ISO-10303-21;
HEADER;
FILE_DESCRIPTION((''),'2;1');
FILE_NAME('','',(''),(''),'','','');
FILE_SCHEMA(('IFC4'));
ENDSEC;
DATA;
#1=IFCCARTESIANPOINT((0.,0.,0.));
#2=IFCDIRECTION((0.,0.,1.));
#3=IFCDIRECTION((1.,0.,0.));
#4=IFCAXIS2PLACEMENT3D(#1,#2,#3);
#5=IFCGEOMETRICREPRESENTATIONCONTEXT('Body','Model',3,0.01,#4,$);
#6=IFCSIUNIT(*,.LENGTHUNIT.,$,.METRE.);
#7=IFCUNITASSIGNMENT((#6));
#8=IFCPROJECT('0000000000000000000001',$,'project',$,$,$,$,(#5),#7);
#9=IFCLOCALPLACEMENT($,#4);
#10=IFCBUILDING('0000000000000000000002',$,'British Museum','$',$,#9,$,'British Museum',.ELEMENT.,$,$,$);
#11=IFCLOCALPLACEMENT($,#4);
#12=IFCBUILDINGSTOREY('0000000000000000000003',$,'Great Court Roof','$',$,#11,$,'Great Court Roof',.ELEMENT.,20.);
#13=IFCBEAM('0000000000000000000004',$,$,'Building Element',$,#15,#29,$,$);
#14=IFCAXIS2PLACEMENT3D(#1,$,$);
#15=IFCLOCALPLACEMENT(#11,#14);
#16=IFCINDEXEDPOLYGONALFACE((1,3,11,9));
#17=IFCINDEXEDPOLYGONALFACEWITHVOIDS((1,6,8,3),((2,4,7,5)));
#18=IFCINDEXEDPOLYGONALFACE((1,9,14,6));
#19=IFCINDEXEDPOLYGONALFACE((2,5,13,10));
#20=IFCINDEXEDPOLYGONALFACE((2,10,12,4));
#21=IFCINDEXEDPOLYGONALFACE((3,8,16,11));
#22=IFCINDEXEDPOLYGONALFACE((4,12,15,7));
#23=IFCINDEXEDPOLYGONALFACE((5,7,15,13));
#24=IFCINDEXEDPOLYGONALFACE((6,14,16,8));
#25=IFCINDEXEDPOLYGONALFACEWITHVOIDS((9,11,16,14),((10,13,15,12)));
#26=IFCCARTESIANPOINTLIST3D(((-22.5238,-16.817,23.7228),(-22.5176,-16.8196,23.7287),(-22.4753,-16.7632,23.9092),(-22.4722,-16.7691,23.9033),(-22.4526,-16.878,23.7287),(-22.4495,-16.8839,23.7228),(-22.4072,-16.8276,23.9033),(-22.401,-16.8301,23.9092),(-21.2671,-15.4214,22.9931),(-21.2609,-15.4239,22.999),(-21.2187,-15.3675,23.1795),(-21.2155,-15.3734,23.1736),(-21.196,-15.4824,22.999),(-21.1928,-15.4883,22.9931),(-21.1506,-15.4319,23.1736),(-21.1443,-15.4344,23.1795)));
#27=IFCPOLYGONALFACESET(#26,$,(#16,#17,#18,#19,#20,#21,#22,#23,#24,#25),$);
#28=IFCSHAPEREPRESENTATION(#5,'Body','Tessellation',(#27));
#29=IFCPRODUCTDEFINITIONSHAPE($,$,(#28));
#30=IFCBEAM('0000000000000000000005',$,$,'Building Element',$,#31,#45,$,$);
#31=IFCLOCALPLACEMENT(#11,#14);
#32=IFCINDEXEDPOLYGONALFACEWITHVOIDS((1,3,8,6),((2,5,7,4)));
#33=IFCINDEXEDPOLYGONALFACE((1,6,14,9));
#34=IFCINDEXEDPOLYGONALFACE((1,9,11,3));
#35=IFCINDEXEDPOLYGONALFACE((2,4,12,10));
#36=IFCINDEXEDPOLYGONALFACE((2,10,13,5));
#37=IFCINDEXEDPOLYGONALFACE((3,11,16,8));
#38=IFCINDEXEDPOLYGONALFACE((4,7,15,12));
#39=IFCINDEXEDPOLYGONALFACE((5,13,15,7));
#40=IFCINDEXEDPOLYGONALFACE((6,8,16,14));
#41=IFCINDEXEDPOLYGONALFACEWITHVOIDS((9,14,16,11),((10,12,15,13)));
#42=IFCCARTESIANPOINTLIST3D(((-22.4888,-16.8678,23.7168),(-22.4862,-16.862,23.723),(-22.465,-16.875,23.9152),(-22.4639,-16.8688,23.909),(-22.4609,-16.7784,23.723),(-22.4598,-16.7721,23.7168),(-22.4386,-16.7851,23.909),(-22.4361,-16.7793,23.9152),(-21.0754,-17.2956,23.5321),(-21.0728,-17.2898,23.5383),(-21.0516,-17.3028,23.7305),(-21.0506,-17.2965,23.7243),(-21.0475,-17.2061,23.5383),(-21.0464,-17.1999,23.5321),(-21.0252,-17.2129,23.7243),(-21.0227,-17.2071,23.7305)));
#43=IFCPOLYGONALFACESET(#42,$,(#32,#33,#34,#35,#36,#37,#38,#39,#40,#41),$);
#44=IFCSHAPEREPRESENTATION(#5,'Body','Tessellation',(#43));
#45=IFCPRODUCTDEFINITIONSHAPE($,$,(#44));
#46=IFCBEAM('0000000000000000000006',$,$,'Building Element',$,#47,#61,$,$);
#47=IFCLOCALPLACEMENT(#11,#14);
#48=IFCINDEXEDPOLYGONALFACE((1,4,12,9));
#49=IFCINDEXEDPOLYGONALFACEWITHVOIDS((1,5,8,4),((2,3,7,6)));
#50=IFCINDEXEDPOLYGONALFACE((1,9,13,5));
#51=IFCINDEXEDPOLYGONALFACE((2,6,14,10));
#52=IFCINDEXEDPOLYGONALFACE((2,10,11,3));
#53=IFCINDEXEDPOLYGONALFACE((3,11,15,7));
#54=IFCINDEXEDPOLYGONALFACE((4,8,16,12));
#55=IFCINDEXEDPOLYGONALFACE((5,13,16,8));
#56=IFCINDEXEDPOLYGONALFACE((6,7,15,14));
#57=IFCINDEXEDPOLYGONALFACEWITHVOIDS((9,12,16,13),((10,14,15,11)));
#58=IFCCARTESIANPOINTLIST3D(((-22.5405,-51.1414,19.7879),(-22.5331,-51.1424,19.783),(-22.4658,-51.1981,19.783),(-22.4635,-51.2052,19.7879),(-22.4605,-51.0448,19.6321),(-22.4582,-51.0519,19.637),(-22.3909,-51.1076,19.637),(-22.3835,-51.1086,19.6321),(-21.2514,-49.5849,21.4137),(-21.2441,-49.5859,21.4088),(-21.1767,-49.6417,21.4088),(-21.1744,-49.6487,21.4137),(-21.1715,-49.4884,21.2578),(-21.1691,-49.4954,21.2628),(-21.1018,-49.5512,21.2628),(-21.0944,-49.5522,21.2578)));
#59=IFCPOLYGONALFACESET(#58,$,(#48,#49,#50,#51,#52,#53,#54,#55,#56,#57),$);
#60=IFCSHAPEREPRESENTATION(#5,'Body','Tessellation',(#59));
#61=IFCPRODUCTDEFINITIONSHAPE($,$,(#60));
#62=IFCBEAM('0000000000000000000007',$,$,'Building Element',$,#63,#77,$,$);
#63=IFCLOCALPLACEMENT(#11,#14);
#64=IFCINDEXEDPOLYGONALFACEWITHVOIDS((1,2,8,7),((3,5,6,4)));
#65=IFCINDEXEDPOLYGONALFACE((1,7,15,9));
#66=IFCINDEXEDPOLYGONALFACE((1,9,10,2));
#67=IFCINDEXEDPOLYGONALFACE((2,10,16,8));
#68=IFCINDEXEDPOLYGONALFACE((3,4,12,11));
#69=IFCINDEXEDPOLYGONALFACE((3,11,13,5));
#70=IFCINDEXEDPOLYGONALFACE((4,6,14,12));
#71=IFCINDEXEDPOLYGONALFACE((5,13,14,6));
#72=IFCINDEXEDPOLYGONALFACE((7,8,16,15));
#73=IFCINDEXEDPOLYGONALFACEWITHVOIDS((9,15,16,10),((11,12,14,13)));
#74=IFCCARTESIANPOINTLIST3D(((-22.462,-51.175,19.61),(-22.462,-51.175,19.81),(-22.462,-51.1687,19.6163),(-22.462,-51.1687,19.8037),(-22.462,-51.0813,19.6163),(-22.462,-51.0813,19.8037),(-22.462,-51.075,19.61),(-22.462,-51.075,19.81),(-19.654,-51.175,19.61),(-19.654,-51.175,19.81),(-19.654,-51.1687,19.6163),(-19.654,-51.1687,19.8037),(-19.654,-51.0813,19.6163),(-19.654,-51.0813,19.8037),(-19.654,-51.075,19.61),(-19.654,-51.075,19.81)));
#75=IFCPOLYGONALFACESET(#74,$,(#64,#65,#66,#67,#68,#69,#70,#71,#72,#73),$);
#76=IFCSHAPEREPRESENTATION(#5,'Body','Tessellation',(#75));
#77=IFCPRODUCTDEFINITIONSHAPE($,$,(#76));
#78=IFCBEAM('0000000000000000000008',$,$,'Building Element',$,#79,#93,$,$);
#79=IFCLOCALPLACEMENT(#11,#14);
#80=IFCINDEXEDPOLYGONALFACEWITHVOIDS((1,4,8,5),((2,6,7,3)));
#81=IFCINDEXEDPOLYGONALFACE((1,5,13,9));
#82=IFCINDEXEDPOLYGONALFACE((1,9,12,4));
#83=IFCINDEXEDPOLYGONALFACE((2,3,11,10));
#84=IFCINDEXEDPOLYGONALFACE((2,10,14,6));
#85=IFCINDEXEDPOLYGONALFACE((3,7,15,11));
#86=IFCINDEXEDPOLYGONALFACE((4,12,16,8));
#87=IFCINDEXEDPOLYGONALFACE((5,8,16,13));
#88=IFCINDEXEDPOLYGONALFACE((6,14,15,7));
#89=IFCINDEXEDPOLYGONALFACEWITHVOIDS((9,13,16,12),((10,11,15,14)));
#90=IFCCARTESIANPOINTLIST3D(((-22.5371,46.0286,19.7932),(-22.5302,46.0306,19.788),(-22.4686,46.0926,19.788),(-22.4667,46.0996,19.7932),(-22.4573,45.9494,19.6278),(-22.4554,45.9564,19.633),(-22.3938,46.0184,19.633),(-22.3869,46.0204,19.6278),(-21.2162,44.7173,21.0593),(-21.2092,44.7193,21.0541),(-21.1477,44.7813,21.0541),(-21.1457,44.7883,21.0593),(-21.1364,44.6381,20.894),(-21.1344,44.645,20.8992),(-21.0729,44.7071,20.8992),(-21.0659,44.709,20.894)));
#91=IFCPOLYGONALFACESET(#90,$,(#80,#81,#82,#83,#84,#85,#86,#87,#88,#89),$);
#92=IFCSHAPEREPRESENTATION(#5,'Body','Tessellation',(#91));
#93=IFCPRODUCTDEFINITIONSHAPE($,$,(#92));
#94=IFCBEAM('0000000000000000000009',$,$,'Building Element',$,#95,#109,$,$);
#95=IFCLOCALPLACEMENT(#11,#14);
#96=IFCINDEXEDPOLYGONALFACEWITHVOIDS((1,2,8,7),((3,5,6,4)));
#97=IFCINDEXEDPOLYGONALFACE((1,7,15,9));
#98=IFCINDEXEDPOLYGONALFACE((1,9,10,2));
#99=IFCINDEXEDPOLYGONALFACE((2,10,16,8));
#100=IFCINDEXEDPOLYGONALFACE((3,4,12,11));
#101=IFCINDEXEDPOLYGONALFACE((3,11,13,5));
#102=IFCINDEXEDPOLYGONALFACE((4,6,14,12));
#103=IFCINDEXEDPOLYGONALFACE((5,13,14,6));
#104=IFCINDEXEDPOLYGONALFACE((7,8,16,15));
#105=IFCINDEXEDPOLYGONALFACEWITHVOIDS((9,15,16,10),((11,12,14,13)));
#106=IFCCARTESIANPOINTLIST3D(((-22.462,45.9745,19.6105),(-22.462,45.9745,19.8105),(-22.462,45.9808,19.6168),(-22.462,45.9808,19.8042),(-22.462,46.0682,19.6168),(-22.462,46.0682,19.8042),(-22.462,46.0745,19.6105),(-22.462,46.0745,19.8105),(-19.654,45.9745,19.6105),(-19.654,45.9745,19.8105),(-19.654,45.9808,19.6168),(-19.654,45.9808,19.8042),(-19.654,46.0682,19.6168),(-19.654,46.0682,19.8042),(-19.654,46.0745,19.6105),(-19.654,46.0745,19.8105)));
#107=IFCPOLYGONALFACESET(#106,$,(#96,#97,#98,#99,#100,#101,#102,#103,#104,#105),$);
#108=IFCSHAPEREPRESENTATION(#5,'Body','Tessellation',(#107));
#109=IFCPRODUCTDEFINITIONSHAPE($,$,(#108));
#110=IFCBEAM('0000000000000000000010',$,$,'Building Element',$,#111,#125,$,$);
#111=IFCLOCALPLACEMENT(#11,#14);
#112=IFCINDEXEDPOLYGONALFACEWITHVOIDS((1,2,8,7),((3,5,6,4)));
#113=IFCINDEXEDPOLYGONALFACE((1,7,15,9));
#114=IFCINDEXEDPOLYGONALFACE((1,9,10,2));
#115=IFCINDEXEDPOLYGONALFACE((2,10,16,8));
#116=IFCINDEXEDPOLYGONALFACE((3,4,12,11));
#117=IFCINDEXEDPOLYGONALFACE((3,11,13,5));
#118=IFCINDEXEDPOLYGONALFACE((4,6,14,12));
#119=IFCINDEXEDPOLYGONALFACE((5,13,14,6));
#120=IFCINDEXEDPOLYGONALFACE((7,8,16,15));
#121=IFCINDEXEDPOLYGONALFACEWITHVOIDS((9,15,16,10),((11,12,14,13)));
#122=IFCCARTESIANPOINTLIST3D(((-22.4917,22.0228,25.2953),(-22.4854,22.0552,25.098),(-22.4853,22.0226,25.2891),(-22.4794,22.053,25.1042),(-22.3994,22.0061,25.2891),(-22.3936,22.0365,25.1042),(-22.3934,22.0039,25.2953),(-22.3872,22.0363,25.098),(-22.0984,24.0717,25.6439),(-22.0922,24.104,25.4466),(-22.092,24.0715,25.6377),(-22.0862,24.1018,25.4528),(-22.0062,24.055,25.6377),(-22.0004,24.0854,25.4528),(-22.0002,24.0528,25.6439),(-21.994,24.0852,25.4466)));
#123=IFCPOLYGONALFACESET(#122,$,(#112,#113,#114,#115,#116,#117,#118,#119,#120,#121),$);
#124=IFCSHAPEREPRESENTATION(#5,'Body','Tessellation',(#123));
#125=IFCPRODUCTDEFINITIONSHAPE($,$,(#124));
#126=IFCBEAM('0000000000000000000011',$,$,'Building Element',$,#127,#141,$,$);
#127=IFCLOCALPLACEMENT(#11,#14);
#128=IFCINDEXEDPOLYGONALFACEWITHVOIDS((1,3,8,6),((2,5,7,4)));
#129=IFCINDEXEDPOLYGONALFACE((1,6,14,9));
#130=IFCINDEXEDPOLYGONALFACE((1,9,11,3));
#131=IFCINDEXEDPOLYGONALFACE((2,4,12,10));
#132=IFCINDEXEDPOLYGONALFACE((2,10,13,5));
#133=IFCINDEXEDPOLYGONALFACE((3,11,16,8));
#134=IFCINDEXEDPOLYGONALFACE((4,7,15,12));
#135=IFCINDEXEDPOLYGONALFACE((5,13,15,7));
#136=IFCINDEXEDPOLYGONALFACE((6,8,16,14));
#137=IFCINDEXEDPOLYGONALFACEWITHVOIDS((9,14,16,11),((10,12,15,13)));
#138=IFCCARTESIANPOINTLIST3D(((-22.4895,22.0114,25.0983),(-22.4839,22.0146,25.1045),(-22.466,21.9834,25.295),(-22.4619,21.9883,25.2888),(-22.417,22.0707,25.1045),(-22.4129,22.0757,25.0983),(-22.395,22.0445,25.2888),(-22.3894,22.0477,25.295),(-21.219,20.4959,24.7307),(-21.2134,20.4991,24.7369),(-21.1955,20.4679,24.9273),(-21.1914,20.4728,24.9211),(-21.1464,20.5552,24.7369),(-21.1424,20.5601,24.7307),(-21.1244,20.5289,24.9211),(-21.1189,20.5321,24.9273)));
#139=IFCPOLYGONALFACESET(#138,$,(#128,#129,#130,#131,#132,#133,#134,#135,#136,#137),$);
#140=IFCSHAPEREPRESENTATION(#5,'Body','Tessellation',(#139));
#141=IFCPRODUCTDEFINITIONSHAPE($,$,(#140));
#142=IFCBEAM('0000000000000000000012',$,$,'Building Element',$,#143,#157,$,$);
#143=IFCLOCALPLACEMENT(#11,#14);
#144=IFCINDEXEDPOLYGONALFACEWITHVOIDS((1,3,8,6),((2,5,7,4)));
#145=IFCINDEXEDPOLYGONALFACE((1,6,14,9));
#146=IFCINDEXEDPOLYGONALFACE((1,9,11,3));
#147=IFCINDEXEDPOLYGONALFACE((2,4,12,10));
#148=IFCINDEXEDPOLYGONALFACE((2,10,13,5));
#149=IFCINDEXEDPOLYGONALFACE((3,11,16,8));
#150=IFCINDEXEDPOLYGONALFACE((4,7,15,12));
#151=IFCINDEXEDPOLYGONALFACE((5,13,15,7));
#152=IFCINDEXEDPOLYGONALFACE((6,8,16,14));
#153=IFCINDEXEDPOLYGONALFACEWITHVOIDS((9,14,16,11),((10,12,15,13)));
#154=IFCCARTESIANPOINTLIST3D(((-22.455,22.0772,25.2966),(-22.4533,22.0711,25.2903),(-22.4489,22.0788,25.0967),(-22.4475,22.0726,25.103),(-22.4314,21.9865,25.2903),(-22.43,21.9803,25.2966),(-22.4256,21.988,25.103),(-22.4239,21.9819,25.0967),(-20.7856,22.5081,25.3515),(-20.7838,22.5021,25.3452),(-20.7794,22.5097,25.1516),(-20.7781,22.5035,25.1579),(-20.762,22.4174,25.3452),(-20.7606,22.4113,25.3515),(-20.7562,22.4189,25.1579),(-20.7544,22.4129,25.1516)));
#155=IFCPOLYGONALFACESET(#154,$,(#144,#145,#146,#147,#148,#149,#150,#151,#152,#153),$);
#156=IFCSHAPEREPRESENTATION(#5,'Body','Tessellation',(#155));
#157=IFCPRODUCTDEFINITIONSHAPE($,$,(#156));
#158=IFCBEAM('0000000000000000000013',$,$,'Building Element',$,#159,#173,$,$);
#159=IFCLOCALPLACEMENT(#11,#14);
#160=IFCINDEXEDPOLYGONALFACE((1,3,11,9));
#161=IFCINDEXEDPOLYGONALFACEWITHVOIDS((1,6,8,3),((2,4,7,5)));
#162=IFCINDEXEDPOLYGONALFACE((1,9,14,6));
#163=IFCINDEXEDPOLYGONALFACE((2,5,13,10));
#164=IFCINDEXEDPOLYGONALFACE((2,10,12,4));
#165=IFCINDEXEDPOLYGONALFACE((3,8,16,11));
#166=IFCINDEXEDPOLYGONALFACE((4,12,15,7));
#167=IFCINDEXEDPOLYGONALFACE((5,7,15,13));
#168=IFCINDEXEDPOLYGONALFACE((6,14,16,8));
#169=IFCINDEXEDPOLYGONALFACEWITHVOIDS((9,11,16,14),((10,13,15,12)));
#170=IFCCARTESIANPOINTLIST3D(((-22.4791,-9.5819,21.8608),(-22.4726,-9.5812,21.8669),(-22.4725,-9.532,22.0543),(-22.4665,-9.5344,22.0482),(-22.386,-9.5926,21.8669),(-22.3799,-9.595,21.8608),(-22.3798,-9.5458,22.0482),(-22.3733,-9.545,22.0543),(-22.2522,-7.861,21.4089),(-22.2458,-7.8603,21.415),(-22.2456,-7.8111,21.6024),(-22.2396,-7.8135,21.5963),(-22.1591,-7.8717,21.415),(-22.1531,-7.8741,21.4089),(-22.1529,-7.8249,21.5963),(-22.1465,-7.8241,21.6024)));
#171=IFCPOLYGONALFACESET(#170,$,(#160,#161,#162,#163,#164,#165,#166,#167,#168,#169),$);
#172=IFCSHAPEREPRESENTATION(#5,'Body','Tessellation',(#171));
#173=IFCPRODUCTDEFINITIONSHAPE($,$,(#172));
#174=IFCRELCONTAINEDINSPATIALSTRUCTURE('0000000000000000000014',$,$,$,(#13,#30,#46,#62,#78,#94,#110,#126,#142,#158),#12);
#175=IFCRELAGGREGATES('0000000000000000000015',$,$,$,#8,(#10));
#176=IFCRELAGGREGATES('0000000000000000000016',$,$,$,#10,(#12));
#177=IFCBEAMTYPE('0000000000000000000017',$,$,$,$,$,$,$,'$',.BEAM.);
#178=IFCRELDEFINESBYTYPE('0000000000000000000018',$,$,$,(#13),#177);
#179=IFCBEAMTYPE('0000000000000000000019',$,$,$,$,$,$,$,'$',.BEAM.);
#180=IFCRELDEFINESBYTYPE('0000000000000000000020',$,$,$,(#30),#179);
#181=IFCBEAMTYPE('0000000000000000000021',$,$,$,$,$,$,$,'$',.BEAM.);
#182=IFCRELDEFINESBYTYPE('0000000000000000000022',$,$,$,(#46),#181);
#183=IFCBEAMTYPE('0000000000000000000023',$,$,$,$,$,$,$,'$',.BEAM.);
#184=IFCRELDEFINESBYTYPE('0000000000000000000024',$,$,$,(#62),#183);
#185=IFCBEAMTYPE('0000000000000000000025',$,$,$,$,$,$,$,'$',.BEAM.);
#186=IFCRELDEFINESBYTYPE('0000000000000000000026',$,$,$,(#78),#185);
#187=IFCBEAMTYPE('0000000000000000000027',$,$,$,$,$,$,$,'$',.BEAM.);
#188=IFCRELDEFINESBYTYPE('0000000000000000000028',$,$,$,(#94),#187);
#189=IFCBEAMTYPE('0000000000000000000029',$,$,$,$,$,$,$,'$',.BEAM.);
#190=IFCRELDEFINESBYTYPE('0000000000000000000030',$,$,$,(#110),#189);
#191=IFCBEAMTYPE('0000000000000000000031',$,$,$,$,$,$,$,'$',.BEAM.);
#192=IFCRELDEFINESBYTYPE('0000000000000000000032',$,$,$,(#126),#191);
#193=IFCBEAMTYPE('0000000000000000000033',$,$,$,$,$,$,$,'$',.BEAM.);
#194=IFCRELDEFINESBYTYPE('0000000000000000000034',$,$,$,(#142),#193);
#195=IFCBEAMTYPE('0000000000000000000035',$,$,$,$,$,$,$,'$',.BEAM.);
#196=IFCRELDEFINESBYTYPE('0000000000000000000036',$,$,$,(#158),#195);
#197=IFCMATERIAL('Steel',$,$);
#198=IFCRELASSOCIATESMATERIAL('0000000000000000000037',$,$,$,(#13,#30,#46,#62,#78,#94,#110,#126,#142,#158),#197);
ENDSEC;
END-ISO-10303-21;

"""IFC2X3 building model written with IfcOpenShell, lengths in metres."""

from ifc_helpers import new_model, si_unit, frame, origin_with_axes, origin_2d, place, context, project, spatial, hollow_rectangle, extrude, material, type_object, element, save


model = new_model("IFC2X3")

# Units and contexts
model_context = context("Model", 3, precision=0.01, world=origin_with_axes(), identifier="Body")
ifc_project = project(units=[si_unit("LENGTHUNIT", "METRE")], contexts=[model_context])

# Building, storey
building_placement = place(None, origin_with_axes())
building = spatial("IfcBuilding", under=ifc_project, at=building_placement, Name="British Museum", Description="$", LongName="British Museum", CompositionType="ELEMENT")
storey_placement = place(None, origin_with_axes())
storey = spatial("IfcBuildingStorey", under=building, at=storey_placement, Name="Great Court Roof", Description="$", LongName="Great Court Roof", CompositionType="ELEMENT", Elevation=20.0)

# Beams
ifc_material = material(Name="Steel")
beam_type_1 = type_object("IfcBeamType", ElementType="$", PredefinedType="BEAM")
beam_1_placement = place(None, origin_with_axes())
element("IfcBeam", 1, at=beam_1_placement, inside=storey, type_object=beam_type_1, material=ifc_material, Description="Building Element", context=model_context, shape_type="SweptSolid", body=[
    extrude(hollow_rectangle(XDim=0.1, YDim=0.2, WallThickness=0.0063, InnerFilletRadius=-0.0063, OuterFilletRadius=0.0, at=origin_2d()), frame((-22.4624, -16.8236, 23.816), z_axis=(0.623709, 0.692696, -0.362158), x_axis=(-0.743143, 0.669132, 0.0)), (0.0, 0.0, 1.0), 2.0148),
])
beam_type_2 = type_object("IfcBeamType", ElementType="$", PredefinedType="BEAM")
beam_2_placement = place(None, origin_with_axes())
element("IfcBeam", 2, at=beam_2_placement, inside=storey, type_object=beam_type_2, material=ifc_material, Description="Building Element", context=model_context, shape_type="SweptSolid", body=[
    extrude(hollow_rectangle(XDim=0.1, YDim=0.2, WallThickness=0.0063, InnerFilletRadius=-0.0063, OuterFilletRadius=0.0, at=origin_2d()), frame((-22.4624, -16.8236, 23.816), z_axis=(0.94973, -0.287426, -0.124095), x_axis=(0.289665, 0.957128, 0.0)), (0.0, 0.0, 1.0), 1.4882),
])
beam_type_3 = type_object("IfcBeamType", ElementType="$", PredefinedType="BEAM")
beam_3_placement = place(None, origin_with_axes())
element("IfcBeam", 3, at=beam_3_placement, inside=storey, type_object=beam_type_3, material=ifc_material, Description="Building Element", context=model_context, shape_type="SweptSolid", body=[
    extrude(hollow_rectangle(XDim=0.1, YDim=0.2, WallThickness=0.0063, InnerFilletRadius=-0.0063, OuterFilletRadius=0.0, at=origin_2d()), frame((-22.462, -51.125, 19.71), z_axis=(0.496997, 0.600088, 0.626809), x_axis=(-0.770159, 0.637851, 0.0)), (0.0, 0.0, 1.0), 2.5937),
])
beam_type_4 = type_object("IfcBeamType", ElementType="$", PredefinedType="BEAM")
beam_4_placement = place(None, origin_with_axes())
element("IfcBeam", 4, at=beam_4_placement, inside=storey, type_object=beam_type_4, material=ifc_material, Description="Building Element", context=model_context, shape_type="SweptSolid", body=[
    extrude(hollow_rectangle(XDim=0.1, YDim=0.2, WallThickness=0.0063, InnerFilletRadius=-0.0063, OuterFilletRadius=0.0, at=origin_2d()), frame((-22.462, -51.125, 19.71), z_axis=(1.0, 0.0, 0.0), x_axis=(0.0, 1.0, 0.0)), (0.0, 0.0, 1.0), 2.808),
])
beam_type_5 = type_object("IfcBeamType", ElementType="$", PredefinedType="BEAM")
beam_5_placement = place(None, origin_with_axes())
element("IfcBeam", 5, at=beam_5_placement, inside=storey, type_object=beam_type_5, material=ifc_material, Description="Building Element", context=model_context, shape_type="SweptSolid", body=[
    extrude(hollow_rectangle(XDim=0.1, YDim=0.2, WallThickness=0.0063, InnerFilletRadius=-0.0063, OuterFilletRadius=0.0, at=origin_2d()), frame((-22.462, 46.0245, 19.7105), z_axis=(0.586789, -0.582511, 0.562458), x_axis=(0.704515, 0.709689, 0.0)), (0.0, 0.0, 1.0), 2.2512),
])
beam_type_6 = type_object("IfcBeamType", ElementType="$", PredefinedType="BEAM")
beam_6_placement = place(None, origin_with_axes())
element("IfcBeam", 6, at=beam_6_placement, inside=storey, type_object=beam_type_6, material=ifc_material, Description="Building Element", context=model_context, shape_type="SweptSolid", body=[
    extrude(hollow_rectangle(XDim=0.1, YDim=0.2, WallThickness=0.0063, InnerFilletRadius=-0.0063, OuterFilletRadius=0.0, at=origin_2d()), frame((-22.462, 46.0245, 19.7105), z_axis=(1.0, 0.0, 0.000011), x_axis=(0.0, 1.0, 0.0)), (0.0, 0.0, 1.0), 2.808),
])
beam_type_7 = type_object("IfcBeamType", ElementType="$", PredefinedType="BEAM")
beam_7_placement = place(None, origin_with_axes())
element("IfcBeam", 7, at=beam_7_placement, inside=storey, type_object=beam_type_7, material=ifc_material, Description="Building Element", context=model_context, shape_type="SweptSolid", body=[
    extrude(hollow_rectangle(XDim=0.1, YDim=0.2, WallThickness=0.0063, InnerFilletRadius=-0.0063, OuterFilletRadius=0.0, at=origin_2d()), frame((-22.4394, 22.0295, 25.1966), z_axis=(0.185911, 0.968646, 0.164809), x_axis=(-0.982075, 0.188488, 0.0)), (0.0, 0.0, 1.0), 2.1152),
])
beam_type_8 = type_object("IfcBeamType", ElementType="$", PredefinedType="BEAM")
beam_8_placement = place(None, origin_with_axes())
element("IfcBeam", 8, at=beam_8_placement, inside=storey, type_object=beam_type_8, material=ifc_material, Description="Building Element", context=model_context, shape_type="SweptSolid", body=[
    extrude(hollow_rectangle(XDim=0.1, YDim=0.2, WallThickness=0.0063, InnerFilletRadius=-0.0063, OuterFilletRadius=0.0, at=origin_2d()), frame((-22.4394, 22.0295, 25.1966), z_axis=(0.631614, -0.75343, -0.182778), x_axis=(0.766339, 0.642436, 0.0)), (0.0, 0.0, 1.0), 2.0115),
])
beam_type_9 = type_object("IfcBeamType", ElementType="$", PredefinedType="BEAM")
beam_9_placement = place(None, origin_with_axes())
element("IfcBeam", 9, at=beam_9_placement, inside=storey, type_object=beam_type_9, material=ifc_material, Description="Building Element", context=model_context, shape_type="SweptSolid", body=[
    extrude(hollow_rectangle(XDim=0.1, YDim=0.2, WallThickness=0.0063, InnerFilletRadius=-0.0063, OuterFilletRadius=0.0, at=origin_2d()), frame((-22.4394, 22.0295, 25.1966), z_axis=(0.967771, 0.249815, 0.031807), x_axis=(-0.249942, 0.968261, 0.0)), (0.0, 0.0, 1.0), 1.725),
])
beam_type_10 = type_object("IfcBeamType", ElementType="$", PredefinedType="BEAM")
beam_10_placement = place(None, origin_with_axes())
element("IfcBeam", 10, at=beam_10_placement, inside=storey, type_object=beam_type_10, material=ifc_material, Description="Building Element", context=model_context, shape_type="SweptSolid", body=[
    extrude(hollow_rectangle(XDim=0.1, YDim=0.2, WallThickness=0.0063, InnerFilletRadius=-0.0063, OuterFilletRadius=0.0, at=origin_2d()), frame((-22.4262, -9.5635, 21.9575), z_axis=(0.126484, 0.959437, -0.251956), x_axis=(-0.991422, 0.1307, 0.0)), (0.0, 0.0, 1.0), 1.7936),
])

save(model, "model.ifc")
